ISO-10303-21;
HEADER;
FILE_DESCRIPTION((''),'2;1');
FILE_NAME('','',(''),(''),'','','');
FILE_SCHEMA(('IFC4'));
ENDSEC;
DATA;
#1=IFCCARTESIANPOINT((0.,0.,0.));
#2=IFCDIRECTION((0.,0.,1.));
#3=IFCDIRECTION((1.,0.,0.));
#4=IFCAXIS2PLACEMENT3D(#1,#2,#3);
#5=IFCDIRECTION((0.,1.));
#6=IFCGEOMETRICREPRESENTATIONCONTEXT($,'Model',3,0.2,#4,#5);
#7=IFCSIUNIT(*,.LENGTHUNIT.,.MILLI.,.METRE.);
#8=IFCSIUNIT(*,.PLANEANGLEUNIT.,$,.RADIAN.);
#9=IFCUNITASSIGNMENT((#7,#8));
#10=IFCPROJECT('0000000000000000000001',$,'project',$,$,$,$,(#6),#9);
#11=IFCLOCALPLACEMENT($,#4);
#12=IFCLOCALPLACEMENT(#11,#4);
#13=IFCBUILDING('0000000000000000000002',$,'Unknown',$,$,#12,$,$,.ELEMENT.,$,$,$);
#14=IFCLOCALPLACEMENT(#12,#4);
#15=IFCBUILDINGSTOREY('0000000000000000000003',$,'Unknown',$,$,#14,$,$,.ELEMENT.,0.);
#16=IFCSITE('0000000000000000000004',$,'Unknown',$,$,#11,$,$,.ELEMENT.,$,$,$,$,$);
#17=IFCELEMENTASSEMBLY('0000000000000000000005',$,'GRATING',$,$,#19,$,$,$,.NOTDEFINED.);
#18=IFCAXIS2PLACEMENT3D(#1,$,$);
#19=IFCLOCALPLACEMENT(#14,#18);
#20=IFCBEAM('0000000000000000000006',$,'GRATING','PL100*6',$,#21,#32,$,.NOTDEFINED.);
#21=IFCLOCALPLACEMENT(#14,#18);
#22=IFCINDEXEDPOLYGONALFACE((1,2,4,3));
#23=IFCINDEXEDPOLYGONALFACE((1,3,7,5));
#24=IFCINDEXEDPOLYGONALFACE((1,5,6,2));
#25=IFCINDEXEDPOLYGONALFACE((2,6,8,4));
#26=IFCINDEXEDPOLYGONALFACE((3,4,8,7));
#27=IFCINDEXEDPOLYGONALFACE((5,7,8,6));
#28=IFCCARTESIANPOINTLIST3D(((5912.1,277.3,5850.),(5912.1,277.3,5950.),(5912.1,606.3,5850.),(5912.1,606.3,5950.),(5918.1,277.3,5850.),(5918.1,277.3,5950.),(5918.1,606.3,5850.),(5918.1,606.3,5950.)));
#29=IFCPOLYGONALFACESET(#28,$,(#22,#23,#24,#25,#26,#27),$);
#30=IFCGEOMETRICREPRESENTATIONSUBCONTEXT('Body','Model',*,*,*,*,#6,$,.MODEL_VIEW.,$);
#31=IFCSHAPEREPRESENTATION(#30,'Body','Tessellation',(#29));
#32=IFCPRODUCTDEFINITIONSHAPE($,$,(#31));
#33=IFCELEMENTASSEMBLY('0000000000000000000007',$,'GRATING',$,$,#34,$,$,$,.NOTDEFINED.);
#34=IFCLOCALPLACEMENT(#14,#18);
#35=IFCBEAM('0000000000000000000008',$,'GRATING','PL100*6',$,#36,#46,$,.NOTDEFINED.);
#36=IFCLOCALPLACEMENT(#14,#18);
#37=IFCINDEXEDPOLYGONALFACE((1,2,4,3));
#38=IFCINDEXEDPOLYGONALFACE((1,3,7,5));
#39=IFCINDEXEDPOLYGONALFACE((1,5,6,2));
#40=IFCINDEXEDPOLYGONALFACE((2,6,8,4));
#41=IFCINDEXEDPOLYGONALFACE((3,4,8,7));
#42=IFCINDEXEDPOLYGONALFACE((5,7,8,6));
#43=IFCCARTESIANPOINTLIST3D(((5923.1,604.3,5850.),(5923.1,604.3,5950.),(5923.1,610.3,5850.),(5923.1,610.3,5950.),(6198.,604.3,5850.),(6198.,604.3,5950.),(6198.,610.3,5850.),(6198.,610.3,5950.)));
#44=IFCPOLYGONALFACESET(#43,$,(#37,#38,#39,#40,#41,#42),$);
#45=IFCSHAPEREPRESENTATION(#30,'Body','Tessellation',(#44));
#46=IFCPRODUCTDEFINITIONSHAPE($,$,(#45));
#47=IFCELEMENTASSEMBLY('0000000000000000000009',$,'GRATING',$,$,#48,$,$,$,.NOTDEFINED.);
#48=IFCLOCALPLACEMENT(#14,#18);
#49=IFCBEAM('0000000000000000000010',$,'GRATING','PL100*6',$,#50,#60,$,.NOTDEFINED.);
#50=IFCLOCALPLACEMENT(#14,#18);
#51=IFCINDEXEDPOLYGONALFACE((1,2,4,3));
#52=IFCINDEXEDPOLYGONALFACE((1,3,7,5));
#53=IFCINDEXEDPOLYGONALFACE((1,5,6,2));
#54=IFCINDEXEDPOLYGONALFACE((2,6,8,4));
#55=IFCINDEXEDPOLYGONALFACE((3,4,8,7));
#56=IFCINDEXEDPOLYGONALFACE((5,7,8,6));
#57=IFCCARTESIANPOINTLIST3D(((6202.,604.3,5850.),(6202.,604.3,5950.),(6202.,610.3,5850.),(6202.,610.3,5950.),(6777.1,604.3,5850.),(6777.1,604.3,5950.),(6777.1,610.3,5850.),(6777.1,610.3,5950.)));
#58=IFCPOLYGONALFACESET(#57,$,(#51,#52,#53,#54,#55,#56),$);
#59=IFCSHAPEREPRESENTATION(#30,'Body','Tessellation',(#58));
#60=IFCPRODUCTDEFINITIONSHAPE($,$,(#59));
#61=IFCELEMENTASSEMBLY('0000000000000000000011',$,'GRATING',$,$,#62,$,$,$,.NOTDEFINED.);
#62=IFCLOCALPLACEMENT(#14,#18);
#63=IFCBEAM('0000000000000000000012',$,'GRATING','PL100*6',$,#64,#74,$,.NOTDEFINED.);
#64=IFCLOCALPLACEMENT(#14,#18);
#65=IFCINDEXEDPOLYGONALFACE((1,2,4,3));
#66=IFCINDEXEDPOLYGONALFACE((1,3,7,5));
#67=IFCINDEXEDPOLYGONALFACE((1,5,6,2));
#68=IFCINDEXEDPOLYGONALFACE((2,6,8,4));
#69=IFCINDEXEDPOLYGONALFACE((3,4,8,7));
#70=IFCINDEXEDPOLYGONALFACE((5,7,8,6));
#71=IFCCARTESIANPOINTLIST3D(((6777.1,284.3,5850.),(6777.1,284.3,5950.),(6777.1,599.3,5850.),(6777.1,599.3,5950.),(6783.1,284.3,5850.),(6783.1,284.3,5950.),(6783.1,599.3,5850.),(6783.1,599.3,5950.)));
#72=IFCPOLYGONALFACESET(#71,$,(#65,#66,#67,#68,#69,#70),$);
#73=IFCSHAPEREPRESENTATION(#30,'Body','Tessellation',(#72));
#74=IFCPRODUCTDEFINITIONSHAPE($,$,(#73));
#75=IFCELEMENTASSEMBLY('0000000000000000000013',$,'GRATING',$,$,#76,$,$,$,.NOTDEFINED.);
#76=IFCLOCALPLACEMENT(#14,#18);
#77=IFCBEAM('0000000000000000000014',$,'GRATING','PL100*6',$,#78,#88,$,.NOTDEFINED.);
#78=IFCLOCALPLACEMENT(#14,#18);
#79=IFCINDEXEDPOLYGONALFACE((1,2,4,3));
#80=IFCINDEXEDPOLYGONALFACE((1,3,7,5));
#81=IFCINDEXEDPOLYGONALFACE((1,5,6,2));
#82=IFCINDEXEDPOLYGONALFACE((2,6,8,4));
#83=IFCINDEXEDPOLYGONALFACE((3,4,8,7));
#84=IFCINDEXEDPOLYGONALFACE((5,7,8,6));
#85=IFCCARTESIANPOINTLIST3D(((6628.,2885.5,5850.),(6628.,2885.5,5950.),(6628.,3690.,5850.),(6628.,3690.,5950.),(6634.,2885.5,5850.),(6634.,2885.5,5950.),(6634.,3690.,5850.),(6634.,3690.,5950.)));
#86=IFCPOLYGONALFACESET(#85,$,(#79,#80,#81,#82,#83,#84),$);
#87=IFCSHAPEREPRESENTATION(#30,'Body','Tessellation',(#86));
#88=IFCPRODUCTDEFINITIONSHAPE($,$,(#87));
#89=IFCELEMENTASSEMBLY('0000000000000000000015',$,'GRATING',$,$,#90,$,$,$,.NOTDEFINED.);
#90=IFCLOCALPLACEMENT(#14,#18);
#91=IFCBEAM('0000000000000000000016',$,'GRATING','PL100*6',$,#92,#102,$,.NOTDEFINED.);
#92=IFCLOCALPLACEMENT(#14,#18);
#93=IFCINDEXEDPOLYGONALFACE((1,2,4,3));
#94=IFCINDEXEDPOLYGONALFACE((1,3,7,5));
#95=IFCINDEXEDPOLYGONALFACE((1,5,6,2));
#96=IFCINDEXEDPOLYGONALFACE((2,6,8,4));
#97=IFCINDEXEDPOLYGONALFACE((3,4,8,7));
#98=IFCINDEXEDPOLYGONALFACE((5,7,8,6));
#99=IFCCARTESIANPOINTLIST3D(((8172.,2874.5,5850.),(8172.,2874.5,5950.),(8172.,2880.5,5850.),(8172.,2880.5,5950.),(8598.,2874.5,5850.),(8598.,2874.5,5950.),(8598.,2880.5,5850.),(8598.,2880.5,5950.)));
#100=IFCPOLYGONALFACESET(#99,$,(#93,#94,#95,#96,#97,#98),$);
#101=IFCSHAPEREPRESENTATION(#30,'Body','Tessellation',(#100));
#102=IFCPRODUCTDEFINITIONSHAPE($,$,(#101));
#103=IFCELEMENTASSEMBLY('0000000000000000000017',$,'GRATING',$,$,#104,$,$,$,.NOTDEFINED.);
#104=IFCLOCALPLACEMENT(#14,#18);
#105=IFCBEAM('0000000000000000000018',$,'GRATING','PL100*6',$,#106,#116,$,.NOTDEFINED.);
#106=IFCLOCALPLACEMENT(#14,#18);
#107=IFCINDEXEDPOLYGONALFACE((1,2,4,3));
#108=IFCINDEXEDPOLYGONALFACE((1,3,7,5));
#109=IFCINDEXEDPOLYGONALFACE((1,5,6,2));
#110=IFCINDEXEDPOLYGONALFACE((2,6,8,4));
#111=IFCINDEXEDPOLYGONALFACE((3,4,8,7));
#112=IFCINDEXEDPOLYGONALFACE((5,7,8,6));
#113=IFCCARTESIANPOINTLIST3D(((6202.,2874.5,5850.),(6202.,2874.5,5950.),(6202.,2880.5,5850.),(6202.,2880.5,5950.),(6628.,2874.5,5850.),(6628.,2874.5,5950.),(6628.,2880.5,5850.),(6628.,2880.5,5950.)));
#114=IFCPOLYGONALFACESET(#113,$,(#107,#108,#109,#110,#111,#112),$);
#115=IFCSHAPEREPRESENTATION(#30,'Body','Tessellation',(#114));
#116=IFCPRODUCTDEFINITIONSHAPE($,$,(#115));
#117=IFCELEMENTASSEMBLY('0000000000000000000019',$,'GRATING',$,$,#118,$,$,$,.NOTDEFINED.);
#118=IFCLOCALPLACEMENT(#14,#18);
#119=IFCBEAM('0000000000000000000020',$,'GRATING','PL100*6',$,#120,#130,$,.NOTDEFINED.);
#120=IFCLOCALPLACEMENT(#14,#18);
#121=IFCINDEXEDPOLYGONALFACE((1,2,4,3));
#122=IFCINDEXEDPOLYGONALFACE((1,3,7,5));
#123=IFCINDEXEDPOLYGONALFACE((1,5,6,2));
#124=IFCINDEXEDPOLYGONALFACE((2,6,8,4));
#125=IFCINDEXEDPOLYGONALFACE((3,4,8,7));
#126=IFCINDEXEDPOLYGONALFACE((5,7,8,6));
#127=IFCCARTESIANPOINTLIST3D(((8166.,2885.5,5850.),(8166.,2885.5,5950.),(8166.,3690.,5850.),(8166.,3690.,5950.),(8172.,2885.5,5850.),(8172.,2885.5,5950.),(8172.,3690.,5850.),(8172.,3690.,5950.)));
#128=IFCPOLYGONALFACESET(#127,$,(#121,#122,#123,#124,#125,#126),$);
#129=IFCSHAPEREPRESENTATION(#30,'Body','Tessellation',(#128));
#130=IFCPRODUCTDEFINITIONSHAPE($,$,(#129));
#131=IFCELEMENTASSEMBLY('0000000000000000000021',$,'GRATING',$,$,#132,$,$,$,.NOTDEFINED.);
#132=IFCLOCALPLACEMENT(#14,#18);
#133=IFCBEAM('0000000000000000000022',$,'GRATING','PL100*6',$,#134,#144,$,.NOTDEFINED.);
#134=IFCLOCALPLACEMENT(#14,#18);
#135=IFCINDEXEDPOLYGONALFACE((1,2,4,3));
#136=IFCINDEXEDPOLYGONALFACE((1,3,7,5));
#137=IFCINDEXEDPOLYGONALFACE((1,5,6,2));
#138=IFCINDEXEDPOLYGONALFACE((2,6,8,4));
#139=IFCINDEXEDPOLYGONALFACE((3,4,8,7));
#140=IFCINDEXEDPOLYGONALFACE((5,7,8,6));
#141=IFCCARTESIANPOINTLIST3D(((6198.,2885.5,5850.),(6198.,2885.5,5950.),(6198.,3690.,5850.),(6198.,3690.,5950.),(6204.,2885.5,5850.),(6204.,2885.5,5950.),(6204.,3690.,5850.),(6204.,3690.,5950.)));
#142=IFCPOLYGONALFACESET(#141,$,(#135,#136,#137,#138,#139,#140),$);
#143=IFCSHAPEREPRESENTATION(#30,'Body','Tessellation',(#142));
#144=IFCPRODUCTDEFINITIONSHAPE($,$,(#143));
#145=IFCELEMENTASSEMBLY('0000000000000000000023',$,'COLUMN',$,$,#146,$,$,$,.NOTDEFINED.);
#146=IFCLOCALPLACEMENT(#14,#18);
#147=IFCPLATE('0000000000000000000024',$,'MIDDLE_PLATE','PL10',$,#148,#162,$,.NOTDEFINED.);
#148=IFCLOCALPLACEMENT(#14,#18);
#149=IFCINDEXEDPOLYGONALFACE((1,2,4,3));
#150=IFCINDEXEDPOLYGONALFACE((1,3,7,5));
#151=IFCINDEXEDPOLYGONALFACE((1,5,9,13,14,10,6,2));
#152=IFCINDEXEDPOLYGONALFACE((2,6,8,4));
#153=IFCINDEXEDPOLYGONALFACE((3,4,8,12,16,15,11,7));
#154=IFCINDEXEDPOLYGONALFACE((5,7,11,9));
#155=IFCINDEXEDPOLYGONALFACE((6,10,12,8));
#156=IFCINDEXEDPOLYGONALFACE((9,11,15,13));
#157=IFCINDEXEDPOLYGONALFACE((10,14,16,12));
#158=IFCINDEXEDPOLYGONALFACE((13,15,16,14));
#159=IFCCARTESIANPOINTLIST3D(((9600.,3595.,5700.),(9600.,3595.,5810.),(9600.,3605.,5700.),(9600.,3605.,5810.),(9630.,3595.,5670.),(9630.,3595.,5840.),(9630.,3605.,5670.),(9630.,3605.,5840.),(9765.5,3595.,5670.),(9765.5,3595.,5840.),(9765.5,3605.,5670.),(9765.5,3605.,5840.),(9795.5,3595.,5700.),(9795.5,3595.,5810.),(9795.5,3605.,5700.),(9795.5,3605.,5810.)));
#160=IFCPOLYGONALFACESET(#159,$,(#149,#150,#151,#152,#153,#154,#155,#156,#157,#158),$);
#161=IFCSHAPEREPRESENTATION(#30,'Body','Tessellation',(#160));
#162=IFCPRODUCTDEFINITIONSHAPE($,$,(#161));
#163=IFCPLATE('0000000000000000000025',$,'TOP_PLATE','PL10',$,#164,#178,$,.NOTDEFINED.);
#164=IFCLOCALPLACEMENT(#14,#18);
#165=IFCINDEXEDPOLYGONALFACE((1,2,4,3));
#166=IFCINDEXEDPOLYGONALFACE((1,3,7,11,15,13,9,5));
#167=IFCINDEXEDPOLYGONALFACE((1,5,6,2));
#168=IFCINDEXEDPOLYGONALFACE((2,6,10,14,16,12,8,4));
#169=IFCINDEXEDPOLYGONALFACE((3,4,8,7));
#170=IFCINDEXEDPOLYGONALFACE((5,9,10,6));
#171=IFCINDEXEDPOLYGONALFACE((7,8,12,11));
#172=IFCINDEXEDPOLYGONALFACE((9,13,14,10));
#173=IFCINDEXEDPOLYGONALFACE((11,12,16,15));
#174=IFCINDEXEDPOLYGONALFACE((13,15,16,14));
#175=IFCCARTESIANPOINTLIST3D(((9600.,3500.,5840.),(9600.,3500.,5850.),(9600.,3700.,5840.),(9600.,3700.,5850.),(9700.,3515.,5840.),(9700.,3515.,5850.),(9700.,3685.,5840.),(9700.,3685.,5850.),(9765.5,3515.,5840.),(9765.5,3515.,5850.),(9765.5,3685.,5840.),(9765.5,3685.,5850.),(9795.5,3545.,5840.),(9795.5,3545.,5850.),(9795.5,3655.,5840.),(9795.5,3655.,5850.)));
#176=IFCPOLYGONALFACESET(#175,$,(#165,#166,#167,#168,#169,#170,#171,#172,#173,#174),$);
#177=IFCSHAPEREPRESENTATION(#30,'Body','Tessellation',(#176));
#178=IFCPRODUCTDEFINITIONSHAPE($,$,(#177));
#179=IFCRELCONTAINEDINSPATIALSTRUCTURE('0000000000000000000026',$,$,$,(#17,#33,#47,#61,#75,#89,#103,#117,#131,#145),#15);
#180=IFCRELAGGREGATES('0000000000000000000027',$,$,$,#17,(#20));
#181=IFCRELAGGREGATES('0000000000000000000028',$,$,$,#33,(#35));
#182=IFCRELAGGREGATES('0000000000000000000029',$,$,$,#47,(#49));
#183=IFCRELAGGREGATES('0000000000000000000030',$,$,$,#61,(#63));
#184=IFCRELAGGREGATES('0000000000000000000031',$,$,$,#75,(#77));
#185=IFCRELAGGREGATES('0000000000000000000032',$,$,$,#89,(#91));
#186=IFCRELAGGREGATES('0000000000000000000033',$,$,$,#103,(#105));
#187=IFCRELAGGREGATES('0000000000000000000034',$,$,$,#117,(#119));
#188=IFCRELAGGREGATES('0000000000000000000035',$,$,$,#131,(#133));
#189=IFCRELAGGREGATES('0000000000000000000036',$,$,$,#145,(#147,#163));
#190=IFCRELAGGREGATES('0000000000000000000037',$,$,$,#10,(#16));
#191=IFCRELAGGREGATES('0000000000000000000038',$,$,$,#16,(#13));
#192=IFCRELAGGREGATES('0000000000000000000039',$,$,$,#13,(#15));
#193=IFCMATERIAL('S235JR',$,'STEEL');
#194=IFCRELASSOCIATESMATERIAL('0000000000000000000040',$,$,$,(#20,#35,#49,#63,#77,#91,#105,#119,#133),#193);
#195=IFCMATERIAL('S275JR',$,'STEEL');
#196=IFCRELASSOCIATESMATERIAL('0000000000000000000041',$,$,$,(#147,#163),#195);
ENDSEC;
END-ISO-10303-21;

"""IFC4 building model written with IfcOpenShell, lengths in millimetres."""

from ifc_helpers import new_model, si_unit, direction, frame, origin_with_axes, place, context, subcontext, project, spatial, line, indexed_curve, outline, extrude, material, element, aggregate, save


model = new_model("IFC4")

# Units and contexts
model_context = context("Model", 3, precision=0.2, world=origin_with_axes(), true_north=direction((0.0, 1.0)))
body_context = subcontext(model_context, "Body", "Model", "MODEL_VIEW")
ifc_project = project(units=[si_unit("LENGTHUNIT", "METRE", prefix="MILLI"), si_unit("PLANEANGLEUNIT", "RADIAN")], contexts=[model_context])

# Site, building, storey
site_placement = place(None, origin_with_axes())
site = spatial("IfcSite", under=ifc_project, at=site_placement, Name="Unknown", CompositionType="ELEMENT")
building_placement = place(site_placement, origin_with_axes())
building = spatial("IfcBuilding", under=site, at=building_placement, Name="Unknown", CompositionType="ELEMENT")
storey_placement = place(building_placement, origin_with_axes())
storey = spatial("IfcBuildingStorey", under=building, at=storey_placement, Name="Unknown", CompositionType="ELEMENT", Elevation=0.0)

# Shared definitions
ifc_material_1 = material(Name="S275JR", Category="STEEL")

# Element assemblies, beams
assembly_1_placement = place(storey_placement, frame((5002.0, 277.3, 5865.0), z_axis=(0.0, 0.0, 1.0), x_axis=(1.0, 0.0, 0.0)))
assembly_1 = element("IfcElementAssembly", 1, at=assembly_1_placement, inside=storey, Name="GRATING", PredefinedType="NOTDEFINED")
ifc_material_2 = material(Name="S235JR", Category="STEEL")
beam_1_placement = place(assembly_1_placement, frame((913.1, 329.0, 35.0), z_axis=(-1.0, 0.0, 0.0), x_axis=(0.0, -1.0, 0.000002)))
beam_1 = element("IfcBeam", 2, at=beam_1_placement, material=ifc_material_2, Name="GRATING", Description="PL100*6", PredefinedType="NOTDEFINED", context=body_context, shape_type="SolidModel", body=[
    extrude(outline(indexed_curve([(-3.0, -50.0), (3.0, -50.0), (3.0, 50.0), (-3.0, 50.0)], segments=[line(1, 2, 3, 4, 1)])), frame((0.0, 0.0, 0.0), z_axis=(-1.0, 0.0, 0.0), x_axis=(0.0, 0.0, 1.0)), (0.0, -0.000002, -1.0), 329.0),
])
aggregate(assembly_1, [beam_1])
assembly_2_placement = place(storey_placement, frame((5002.0, 610.3, 5865.0), z_axis=(0.0, 0.0, 1.0), x_axis=(1.0, 0.0, 0.0)))
assembly_2 = element("IfcElementAssembly", 3, at=assembly_2_placement, inside=storey, Name="GRATING", PredefinedType="NOTDEFINED")
beam_2_placement = place(assembly_2_placement, frame((921.1, -3.0, 35.0), z_axis=(0.0, -1.0, 0.000002), x_axis=(1.0, 0.0, 0.0)))
beam_2 = element("IfcBeam", 4, at=beam_2_placement, material=ifc_material_2, Name="GRATING", Description="PL100*6", PredefinedType="NOTDEFINED", context=body_context, shape_type="SolidModel", body=[
    extrude(outline(indexed_curve([(-3.0, -50.0), (3.0, -50.0), (3.0, 50.0), (-3.0, 50.0)], segments=[line(1, 2, 3, 4, 1)])), frame((0.0, 0.0, 0.0), z_axis=(-1.0, 0.0, 0.0), x_axis=(0.0, 0.0, 1.0)), (0.0, -0.000002, -1.0), 274.9),
])
aggregate(assembly_2, [beam_2])
assembly_3_placement = place(storey_placement, frame((6202.0, 610.3, 5865.0), z_axis=(0.0, 0.0, 1.0), x_axis=(1.0, 0.0, 0.0)))
assembly_3 = element("IfcElementAssembly", 5, at=assembly_3_placement, inside=storey, Name="GRATING", PredefinedType="NOTDEFINED")
beam_3_placement = place(assembly_3_placement, frame((0.0, -3.0, 35.0), z_axis=(0.0, -1.0, 0.000002), x_axis=(1.0, 0.0, 0.0)))
beam_3 = element("IfcBeam", 6, at=beam_3_placement, material=ifc_material_2, Name="GRATING", Description="PL100*6", PredefinedType="NOTDEFINED", context=body_context, shape_type="SolidModel", body=[
    extrude(outline(indexed_curve([(-3.0, -50.0), (3.0, -50.0), (3.0, 50.0), (-3.0, 50.0)], segments=[line(1, 2, 3, 4, 1)])), frame((0.0, 0.0, 0.0), z_axis=(-1.0, 0.0, 0.0), x_axis=(0.0, 0.0, 1.0)), (0.0, -0.000002, -1.0), 575.1),
])
aggregate(assembly_3, [beam_3])
assembly_4_placement = place(storey_placement, frame((6783.1, 277.3, 5865.0), z_axis=(0.0, 0.0, 1.0), x_axis=(1.0, 0.0, 0.0)))
assembly_4 = element("IfcElementAssembly", 7, at=assembly_4_placement, inside=storey, Name="GRATING", PredefinedType="NOTDEFINED")
beam_4_placement = place(assembly_4_placement, frame((-3.0, 322.0, 35.0), z_axis=(-1.0, 0.0, 0.0), x_axis=(0.0, -1.0, 0.000002)))
beam_4 = element("IfcBeam", 8, at=beam_4_placement, material=ifc_material_2, Name="GRATING", Description="PL100*6", PredefinedType="NOTDEFINED", context=body_context, shape_type="SolidModel", body=[
    extrude(outline(indexed_curve([(-3.0, -50.0), (3.0, -50.0), (3.0, 50.0), (-3.0, 50.0)], segments=[line(1, 2, 3, 4, 1)])), frame((0.0, 0.0, 0.0), z_axis=(-1.0, 0.0, 0.0), x_axis=(0.0, 0.0, 1.0)), (0.0, -0.000002, -1.0), 315.0),
])
aggregate(assembly_4, [beam_4])
assembly_5_placement = place(storey_placement, frame((6634.0, 3690.0, 5865.0), z_axis=(0.0, -0.000002, -1.0), x_axis=(1.0, 0.0, 0.0)))
assembly_5 = element("IfcElementAssembly", 9, at=assembly_5_placement, inside=storey, Name="GRATING", PredefinedType="NOTDEFINED")
beam_5_placement = place(assembly_5_placement, frame((-3.0, 804.5, -35.0), z_axis=(1.0, 0.0, 0.0), x_axis=(0.0, -1.0, 0.000002)))
beam_5 = element("IfcBeam", 10, at=beam_5_placement, material=ifc_material_2, Name="GRATING", Description="PL100*6", PredefinedType="NOTDEFINED", context=body_context, shape_type="SolidModel", body=[
    extrude(outline(indexed_curve([(-3.0, -50.0), (3.0, -50.0), (3.0, 50.0), (-3.0, 50.0)], segments=[line(1, 2, 3, 4, 1)])), frame((0.0, 0.0, 0.0), z_axis=(-1.0, 0.0, 0.0), x_axis=(0.0, 0.0, 1.0)), (0.0, -0.000002, -1.0), 804.5),
])
aggregate(assembly_5, [beam_5])
assembly_6_placement = place(storey_placement, frame((8598.0, 2874.5, 5865.0), z_axis=(0.0, 0.0, 1.0), x_axis=(-1.0, 0.0, 0.0)))
assembly_6 = element("IfcElementAssembly", 11, at=assembly_6_placement, inside=storey, Name="GRATING", PredefinedType="NOTDEFINED")
beam_6_placement = place(assembly_6_placement, frame((0.0, -3.0, 35.0), z_axis=(0.0, -1.0, 0.000002), x_axis=(1.0, 0.0, 0.0)))
beam_6 = element("IfcBeam", 12, at=beam_6_placement, material=ifc_material_2, Name="GRATING", Description="PL100*6", PredefinedType="NOTDEFINED", context=body_context, shape_type="SolidModel", body=[
    extrude(outline(indexed_curve([(-3.0, -50.0), (3.0, -50.0), (3.0, 50.0), (-3.0, 50.0)], segments=[line(1, 2, 3, 4, 1)])), frame((0.0, 0.0, 0.0), z_axis=(-1.0, 0.0, 0.0), x_axis=(0.0, 0.0, 1.0)), (0.0, -0.000002, -1.0), 426.0),
])
aggregate(assembly_6, [beam_6])
assembly_7_placement = place(storey_placement, frame((6202.0, 2874.5, 5865.0), z_axis=(0.0, -0.000002, -1.0), x_axis=(1.0, 0.0, 0.0)))
assembly_7 = element("IfcElementAssembly", 13, at=assembly_7_placement, inside=storey, Name="GRATING", PredefinedType="NOTDEFINED")
beam_7_placement = place(assembly_7_placement, frame((0.0, -3.0, -35.0), z_axis=(0.0, 1.0, 0.0), x_axis=(1.0, 0.0, 0.0)))
beam_7 = element("IfcBeam", 14, at=beam_7_placement, material=ifc_material_2, Name="GRATING", Description="PL100*6", PredefinedType="NOTDEFINED", context=body_context, shape_type="SolidModel", body=[
    extrude(outline(indexed_curve([(-3.0, -50.0), (3.0, -50.0), (3.0, 50.0), (-3.0, 50.0)], segments=[line(1, 2, 3, 4, 1)])), frame((0.0, 0.0, 0.0), z_axis=(-1.0, 0.0, 0.0), x_axis=(0.0, 0.0, 1.0)), (0.0, -0.000002, -1.0), 426.0),
])
aggregate(assembly_7, [beam_7])
assembly_8_placement = place(storey_placement, frame((8166.0, 3690.0, 5865.0), z_axis=(0.0, 0.0, 1.0), x_axis=(-1.0, 0.0, 0.0)))
assembly_8 = element("IfcElementAssembly", 15, at=assembly_8_placement, inside=storey, Name="GRATING", PredefinedType="NOTDEFINED")
beam_8_placement = place(assembly_8_placement, frame((-3.0, 804.5, 35.0), z_axis=(-1.0, 0.0, 0.0), x_axis=(0.0, -1.0, 0.000002)))
beam_8 = element("IfcBeam", 16, at=beam_8_placement, material=ifc_material_2, Name="GRATING", Description="PL100*6", PredefinedType="NOTDEFINED", context=body_context, shape_type="SolidModel", body=[
    extrude(outline(indexed_curve([(-3.0, -50.0), (3.0, -50.0), (3.0, 50.0), (-3.0, 50.0)], segments=[line(1, 2, 3, 4, 1)])), frame((0.0, 0.0, 0.0), z_axis=(-1.0, 0.0, 0.0), x_axis=(0.0, 0.0, 1.0)), (0.0, -0.000002, -1.0), 804.5),
])
aggregate(assembly_8, [beam_8])
assembly_9_placement = place(storey_placement, frame((6198.0, 3690.0, 5865.0), z_axis=(0.0, 0.0, 1.0), x_axis=(-1.0, 0.0, 0.0)))
assembly_9 = element("IfcElementAssembly", 17, at=assembly_9_placement, inside=storey, Name="GRATING", PredefinedType="NOTDEFINED")
beam_9_placement = place(assembly_9_placement, frame((-3.0, 0.0, 35.0), z_axis=(1.0, 0.0, 0.0), x_axis=(0.0, 1.0, 0.0)))
beam_9 = element("IfcBeam", 18, at=beam_9_placement, material=ifc_material_2, Name="GRATING", Description="PL100*6", PredefinedType="NOTDEFINED", context=body_context, shape_type="SolidModel", body=[
    extrude(outline(indexed_curve([(-3.0, -50.0), (3.0, -50.0), (3.0, 50.0), (-3.0, 50.0)], segments=[line(1, 2, 3, 4, 1)])), frame((0.0, 0.0, 0.0), z_axis=(-1.0, 0.0, 0.0), x_axis=(0.0, 0.0, 1.0)), (0.0, -0.000002, -1.0), 804.5),
])
aggregate(assembly_9, [beam_9])

# Element assembly, plates
assembly_10_placement = place(storey_placement, frame((9800.0, 3600.0, 200.0), z_axis=(-1.0, 0.0, 0.0), x_axis=(0.0, 0.0, 1.0)))
assembly_10 = element("IfcElementAssembly", 19, at=assembly_10_placement, inside=storey, Name="COLUMN", PredefinedType="NOTDEFINED")
plate_1_placement = place(assembly_10_placement, frame((5640.0, 0.0, 200.0), z_axis=(0.0, 1.0, 0.0), x_axis=(0.0, -0.000002, -1.0)))
plate_1 = element("IfcPlate", 20, at=plate_1_placement, material=ifc_material_1, Name="MIDDLE_PLATE", Description="PL10", PredefinedType="NOTDEFINED", context=body_context, shape_type="SolidModel", body=[
    extrude(outline(indexed_curve([(0.0, 30.0), (30.0, 0.0), (165.5, 0.0), (195.5, 30.0), (195.5, 140.0), (165.5, 170.0), (30.0, 170.0), (0.0, 140.0)], segments=[line(1, 2, 3, 4, 5, 6, 7, 8, 1)])), frame((0.0, 0.0, 5.0), z_axis=(0.0, 0.0, 1.0), x_axis=(1.0, 0.0, 0.0)), (0.0, -0.000002, -1.0), 10.0),
])
plate_2_placement = place(assembly_10_placement, frame((5645.0, -85.0, 100.0), z_axis=(1.0, 0.0, 0.0), x_axis=(0.0, -0.000002, -1.0)))
plate_2 = element("IfcPlate", 21, at=plate_2_placement, material=ifc_material_1, Name="TOP_PLATE", Description="PL10", PredefinedType="NOTDEFINED", context=body_context, shape_type="SolidModel", body=[
    extrude(outline(indexed_curve([(0.0, 0.0), (65.5, 0.0), (95.5, 30.0), (95.5, 140.0), (65.5, 170.0), (0.0, 170.0), (-100.0, 185.0), (-100.0, -15.0)], segments=[line(1, 2, 3, 4, 5, 6, 7, 8, 1)])), frame((0.0, 0.0, 5.0), z_axis=(0.0, 0.0, 1.0), x_axis=(1.0, 0.0, 0.0)), (0.0, -0.000002, -1.0), 10.0),
])

aggregate(assembly_10, [plate_1, plate_2])

save(model, "model.ifc")
